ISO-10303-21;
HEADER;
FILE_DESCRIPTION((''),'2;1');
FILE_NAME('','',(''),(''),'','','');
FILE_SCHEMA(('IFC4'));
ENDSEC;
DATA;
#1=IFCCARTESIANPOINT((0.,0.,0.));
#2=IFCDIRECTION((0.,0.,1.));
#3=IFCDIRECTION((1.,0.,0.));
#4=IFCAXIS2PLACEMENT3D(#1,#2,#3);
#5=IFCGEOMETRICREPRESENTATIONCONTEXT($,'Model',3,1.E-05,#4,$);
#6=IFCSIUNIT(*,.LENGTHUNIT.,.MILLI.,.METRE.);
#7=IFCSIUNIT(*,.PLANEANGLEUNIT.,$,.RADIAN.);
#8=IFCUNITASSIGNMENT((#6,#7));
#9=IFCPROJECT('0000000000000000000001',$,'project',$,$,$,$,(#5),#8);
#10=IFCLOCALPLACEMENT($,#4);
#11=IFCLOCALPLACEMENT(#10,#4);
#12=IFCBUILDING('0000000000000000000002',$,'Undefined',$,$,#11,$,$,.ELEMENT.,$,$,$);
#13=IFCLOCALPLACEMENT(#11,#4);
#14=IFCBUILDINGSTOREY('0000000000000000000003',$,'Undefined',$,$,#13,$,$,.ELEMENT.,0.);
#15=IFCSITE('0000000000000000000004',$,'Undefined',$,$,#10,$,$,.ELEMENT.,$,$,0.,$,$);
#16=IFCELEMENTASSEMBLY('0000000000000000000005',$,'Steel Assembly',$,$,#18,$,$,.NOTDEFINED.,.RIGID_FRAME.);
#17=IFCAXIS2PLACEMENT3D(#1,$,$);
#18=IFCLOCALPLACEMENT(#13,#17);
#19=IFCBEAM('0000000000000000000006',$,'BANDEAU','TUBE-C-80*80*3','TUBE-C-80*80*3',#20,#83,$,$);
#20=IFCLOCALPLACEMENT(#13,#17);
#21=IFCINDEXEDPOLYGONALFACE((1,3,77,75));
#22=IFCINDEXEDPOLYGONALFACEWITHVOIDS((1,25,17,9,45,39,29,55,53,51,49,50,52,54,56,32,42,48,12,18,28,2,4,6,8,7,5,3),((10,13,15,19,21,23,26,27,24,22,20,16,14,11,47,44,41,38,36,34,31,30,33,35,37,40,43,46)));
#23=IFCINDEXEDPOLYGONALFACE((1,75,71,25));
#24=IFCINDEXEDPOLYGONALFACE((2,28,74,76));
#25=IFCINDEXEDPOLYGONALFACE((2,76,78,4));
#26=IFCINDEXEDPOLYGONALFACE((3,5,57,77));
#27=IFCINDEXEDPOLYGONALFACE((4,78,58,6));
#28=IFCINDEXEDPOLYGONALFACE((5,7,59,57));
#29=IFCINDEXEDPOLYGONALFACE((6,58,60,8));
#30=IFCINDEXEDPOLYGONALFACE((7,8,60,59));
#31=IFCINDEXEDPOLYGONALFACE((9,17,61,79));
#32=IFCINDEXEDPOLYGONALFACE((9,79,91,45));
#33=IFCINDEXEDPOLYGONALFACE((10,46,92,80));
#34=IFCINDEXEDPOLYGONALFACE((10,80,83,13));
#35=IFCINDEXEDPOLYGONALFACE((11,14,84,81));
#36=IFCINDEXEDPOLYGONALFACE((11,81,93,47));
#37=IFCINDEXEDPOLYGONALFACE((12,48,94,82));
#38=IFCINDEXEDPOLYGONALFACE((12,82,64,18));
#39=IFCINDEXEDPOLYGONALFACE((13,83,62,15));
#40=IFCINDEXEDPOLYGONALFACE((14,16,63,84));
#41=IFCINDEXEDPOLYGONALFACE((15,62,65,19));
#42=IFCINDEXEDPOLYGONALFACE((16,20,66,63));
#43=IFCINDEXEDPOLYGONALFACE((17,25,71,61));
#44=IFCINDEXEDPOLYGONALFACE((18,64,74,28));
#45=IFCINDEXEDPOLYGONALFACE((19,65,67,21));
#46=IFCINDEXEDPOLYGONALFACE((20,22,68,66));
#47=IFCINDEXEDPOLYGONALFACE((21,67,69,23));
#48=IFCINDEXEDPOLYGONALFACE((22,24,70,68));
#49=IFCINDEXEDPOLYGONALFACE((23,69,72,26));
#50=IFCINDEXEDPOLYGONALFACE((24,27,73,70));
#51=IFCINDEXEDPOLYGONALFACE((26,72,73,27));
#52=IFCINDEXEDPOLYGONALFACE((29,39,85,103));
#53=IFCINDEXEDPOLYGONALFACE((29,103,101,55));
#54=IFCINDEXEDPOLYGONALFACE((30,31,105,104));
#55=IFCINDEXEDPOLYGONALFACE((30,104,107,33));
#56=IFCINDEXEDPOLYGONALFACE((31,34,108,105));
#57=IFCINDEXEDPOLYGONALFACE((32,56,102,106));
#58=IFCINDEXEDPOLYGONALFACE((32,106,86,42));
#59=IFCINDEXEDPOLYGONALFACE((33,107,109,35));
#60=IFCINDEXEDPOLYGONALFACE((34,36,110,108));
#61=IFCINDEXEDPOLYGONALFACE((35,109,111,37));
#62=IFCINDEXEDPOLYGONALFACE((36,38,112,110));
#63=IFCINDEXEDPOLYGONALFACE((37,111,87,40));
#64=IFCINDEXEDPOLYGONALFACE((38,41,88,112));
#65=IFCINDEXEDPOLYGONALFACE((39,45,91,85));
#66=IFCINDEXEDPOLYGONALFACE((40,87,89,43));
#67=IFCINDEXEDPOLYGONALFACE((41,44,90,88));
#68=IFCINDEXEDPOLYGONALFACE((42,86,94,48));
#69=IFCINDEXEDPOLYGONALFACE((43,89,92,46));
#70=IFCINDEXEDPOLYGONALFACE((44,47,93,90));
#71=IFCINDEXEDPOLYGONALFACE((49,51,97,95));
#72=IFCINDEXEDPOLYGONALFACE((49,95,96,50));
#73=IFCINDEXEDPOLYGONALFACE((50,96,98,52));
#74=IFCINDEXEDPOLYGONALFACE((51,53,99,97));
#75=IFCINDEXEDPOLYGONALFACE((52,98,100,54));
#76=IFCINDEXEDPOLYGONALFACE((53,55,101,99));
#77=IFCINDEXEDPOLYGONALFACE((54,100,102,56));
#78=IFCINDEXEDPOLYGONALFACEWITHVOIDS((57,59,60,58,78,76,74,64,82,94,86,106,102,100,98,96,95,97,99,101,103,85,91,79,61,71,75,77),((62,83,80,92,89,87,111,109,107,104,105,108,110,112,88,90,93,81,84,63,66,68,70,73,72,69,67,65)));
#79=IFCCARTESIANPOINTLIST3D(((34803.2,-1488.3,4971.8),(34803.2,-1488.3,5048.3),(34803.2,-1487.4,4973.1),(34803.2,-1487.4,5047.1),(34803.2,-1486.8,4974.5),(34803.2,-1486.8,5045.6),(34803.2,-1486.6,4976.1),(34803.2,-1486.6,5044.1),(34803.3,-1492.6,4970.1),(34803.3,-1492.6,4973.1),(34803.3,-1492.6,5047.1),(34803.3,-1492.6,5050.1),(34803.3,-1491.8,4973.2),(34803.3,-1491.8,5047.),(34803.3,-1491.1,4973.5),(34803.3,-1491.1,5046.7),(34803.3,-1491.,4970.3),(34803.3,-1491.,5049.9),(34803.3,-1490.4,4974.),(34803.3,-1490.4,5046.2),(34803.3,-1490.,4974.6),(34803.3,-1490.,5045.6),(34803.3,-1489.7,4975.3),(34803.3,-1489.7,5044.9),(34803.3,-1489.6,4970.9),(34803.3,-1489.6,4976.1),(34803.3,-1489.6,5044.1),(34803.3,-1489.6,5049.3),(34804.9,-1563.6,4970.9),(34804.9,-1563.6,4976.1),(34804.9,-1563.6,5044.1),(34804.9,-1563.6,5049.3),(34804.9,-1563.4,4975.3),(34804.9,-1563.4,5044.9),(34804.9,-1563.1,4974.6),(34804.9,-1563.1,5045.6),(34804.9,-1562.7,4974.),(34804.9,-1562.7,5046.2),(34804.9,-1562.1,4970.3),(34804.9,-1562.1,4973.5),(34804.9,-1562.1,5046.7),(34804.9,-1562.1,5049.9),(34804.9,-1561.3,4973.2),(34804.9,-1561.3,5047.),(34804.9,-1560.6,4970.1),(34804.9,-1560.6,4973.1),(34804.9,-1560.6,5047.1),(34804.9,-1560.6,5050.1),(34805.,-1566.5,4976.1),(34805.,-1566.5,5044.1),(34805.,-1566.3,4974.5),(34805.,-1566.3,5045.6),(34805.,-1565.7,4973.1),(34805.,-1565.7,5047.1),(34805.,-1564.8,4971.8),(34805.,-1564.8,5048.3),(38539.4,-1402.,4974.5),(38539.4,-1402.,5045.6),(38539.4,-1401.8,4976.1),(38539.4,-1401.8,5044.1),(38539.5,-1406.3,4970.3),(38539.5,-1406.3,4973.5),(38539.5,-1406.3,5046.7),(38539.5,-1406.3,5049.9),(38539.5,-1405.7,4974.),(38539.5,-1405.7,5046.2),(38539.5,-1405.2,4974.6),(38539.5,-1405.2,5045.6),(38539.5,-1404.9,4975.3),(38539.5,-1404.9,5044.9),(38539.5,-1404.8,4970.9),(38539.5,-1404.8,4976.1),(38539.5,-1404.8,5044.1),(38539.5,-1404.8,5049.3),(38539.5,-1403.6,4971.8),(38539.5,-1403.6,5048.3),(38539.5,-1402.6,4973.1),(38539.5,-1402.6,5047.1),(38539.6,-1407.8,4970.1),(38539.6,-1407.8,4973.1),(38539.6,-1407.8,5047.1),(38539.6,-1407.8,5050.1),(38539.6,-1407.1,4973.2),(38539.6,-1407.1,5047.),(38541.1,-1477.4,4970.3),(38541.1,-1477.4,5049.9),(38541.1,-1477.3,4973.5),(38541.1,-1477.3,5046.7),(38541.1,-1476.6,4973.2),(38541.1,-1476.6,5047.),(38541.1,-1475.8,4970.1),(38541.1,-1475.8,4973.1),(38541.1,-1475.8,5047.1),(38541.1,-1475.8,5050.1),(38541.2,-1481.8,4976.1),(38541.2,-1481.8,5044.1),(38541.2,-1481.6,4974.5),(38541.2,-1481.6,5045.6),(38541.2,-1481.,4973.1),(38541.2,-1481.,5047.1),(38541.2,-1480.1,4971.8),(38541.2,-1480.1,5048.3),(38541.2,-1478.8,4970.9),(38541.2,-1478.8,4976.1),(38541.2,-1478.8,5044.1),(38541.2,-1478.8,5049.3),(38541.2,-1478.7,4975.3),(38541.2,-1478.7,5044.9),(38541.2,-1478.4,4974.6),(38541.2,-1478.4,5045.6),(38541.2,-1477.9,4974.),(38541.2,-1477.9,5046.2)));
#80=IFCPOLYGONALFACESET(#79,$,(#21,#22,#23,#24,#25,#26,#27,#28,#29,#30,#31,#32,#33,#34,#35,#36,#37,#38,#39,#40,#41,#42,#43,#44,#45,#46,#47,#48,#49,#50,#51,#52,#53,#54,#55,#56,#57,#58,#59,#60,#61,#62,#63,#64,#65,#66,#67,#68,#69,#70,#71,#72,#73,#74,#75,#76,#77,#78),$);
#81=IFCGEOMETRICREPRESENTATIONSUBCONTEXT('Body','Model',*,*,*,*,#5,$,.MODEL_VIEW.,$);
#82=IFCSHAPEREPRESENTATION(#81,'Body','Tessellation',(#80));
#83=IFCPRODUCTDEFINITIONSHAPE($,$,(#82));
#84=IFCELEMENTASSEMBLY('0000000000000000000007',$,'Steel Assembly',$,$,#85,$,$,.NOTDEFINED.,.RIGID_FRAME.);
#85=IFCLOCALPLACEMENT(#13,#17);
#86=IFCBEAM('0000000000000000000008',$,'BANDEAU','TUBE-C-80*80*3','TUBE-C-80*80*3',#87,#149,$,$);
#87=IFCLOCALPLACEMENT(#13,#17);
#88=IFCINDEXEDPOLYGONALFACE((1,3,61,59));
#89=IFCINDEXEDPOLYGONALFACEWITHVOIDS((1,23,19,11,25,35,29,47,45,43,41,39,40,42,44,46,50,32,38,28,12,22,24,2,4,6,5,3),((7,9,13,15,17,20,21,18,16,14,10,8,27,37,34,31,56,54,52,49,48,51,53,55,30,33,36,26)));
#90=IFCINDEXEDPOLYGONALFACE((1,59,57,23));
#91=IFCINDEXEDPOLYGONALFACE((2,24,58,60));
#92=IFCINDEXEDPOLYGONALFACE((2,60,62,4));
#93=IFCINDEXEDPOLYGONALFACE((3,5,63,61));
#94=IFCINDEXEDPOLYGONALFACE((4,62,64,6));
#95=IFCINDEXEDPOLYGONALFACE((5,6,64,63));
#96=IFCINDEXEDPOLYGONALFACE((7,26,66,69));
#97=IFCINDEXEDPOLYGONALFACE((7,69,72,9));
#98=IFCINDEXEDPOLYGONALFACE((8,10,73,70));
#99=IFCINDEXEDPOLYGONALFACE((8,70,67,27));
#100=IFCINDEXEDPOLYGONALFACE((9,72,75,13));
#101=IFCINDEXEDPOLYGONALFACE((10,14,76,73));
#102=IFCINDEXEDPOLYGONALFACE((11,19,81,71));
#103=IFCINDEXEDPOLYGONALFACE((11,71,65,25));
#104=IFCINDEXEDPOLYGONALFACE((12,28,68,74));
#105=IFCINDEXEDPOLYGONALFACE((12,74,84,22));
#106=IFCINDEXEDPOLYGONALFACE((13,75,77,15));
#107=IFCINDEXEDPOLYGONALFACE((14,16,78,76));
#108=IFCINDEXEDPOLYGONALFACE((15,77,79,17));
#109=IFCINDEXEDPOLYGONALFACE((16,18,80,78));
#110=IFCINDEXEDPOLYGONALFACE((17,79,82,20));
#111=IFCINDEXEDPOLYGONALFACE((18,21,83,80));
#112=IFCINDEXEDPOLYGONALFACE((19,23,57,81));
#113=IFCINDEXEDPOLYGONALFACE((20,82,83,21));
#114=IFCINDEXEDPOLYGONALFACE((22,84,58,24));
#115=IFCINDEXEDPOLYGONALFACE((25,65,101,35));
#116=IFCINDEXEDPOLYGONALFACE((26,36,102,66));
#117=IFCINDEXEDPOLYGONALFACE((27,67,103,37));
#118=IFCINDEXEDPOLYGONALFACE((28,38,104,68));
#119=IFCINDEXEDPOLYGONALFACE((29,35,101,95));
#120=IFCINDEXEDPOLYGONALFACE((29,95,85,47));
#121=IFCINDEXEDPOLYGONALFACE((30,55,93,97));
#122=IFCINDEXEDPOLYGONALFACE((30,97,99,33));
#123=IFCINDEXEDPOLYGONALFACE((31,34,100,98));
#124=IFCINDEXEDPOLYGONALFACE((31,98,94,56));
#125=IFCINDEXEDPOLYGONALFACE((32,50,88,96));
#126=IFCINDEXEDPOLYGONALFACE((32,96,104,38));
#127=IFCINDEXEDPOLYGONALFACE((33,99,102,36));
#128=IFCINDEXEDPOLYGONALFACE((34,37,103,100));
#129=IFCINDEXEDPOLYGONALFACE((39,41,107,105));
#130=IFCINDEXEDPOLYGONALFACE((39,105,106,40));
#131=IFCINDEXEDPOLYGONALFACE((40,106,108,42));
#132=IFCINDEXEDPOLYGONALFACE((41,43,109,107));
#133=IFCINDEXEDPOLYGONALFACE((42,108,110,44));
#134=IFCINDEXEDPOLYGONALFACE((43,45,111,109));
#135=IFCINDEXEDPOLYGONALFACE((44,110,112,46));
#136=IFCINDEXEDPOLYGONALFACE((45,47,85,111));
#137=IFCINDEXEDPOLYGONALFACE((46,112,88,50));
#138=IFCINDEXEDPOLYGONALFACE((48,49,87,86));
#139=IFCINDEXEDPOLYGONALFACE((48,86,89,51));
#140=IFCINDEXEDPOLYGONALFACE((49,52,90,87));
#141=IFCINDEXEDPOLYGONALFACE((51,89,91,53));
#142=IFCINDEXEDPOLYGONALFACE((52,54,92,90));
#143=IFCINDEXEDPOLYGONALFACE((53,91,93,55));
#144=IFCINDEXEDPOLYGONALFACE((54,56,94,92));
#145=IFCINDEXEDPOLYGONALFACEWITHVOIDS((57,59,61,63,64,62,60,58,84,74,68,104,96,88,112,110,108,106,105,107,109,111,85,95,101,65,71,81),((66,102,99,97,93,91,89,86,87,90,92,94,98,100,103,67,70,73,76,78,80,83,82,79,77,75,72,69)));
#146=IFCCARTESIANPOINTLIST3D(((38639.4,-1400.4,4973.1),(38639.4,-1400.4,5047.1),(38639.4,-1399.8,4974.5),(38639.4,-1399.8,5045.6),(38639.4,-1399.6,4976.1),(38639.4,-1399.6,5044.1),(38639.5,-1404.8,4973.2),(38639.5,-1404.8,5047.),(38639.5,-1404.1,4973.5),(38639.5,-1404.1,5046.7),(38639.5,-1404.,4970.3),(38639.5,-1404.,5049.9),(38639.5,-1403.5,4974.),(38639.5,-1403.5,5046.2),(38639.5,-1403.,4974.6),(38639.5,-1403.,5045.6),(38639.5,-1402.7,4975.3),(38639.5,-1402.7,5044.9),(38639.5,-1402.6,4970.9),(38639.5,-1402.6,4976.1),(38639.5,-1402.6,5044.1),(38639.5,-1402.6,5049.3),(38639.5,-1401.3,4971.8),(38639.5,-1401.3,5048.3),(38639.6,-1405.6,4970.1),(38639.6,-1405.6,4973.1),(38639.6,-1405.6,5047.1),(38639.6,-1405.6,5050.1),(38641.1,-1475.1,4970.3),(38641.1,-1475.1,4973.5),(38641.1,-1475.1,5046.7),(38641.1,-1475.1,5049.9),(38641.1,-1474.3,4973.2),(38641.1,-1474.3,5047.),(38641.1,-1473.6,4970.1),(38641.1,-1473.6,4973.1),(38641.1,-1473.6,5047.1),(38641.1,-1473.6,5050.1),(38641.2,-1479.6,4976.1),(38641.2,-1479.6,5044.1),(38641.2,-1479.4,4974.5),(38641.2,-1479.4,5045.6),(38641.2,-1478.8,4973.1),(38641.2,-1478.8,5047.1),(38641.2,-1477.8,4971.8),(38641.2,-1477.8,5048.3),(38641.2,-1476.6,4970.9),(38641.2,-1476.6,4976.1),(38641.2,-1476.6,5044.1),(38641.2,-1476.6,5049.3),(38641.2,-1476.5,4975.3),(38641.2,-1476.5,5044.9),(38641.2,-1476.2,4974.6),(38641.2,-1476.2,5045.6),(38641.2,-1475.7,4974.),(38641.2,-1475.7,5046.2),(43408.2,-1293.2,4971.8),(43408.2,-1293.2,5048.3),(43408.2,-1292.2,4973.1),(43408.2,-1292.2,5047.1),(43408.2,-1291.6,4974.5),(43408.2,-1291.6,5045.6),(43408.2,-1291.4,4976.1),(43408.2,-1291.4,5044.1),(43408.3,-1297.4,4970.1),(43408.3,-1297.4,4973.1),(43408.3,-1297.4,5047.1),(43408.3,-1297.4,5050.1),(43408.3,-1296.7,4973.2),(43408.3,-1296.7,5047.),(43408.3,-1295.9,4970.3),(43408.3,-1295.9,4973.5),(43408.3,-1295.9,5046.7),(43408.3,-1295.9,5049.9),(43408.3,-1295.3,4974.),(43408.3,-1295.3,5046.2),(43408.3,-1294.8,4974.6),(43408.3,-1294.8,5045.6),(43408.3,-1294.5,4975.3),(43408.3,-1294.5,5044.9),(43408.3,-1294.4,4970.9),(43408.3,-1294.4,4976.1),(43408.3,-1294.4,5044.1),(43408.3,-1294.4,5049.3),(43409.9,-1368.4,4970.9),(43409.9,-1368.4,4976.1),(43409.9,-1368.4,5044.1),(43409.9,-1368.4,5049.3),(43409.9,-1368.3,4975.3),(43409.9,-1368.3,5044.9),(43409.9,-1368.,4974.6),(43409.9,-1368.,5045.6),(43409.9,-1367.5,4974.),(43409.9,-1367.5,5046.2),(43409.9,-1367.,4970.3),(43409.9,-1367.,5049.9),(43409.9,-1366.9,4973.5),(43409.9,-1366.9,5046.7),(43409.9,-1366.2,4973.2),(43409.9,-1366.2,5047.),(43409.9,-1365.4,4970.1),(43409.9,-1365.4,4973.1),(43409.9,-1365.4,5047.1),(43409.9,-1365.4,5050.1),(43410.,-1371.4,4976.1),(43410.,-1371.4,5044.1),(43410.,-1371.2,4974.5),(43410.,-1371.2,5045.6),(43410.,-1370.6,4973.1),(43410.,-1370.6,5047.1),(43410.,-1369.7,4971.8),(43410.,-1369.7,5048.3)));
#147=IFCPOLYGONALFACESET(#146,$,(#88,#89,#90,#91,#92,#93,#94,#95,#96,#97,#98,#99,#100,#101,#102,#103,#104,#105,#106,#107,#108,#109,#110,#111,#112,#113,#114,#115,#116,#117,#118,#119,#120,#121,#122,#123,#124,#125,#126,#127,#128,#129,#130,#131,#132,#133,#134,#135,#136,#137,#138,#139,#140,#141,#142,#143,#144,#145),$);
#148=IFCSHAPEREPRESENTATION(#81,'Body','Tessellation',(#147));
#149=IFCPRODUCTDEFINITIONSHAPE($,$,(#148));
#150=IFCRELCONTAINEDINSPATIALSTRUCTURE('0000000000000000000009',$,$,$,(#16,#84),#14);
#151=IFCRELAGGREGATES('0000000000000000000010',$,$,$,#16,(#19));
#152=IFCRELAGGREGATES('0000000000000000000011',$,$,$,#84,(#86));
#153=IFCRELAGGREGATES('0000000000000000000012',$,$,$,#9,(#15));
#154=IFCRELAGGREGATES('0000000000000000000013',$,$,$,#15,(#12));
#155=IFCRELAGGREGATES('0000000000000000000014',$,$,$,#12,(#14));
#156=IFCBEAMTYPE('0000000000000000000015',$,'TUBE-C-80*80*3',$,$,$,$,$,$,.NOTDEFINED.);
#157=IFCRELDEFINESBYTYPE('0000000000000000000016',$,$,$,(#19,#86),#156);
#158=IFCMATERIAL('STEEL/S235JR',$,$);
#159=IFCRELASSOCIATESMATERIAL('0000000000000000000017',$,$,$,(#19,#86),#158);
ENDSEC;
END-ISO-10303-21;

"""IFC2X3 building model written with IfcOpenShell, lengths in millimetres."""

from ifc_helpers import new_model, si_unit, frame, origin_with_axes, origin_2d_with_axis, place, context, subcontext, project, spatial, hollow_rectangle, extrude, material, type_object, element, aggregate, save


model = new_model("IFC2X3")

# Units and contexts
model_context = context("Model", 3, precision=1e-05, world=origin_with_axes())
body_context = subcontext(model_context, "Body", "Model", "MODEL_VIEW")
ifc_project = project(units=[si_unit("LENGTHUNIT", "METRE", prefix="MILLI"), si_unit("PLANEANGLEUNIT", "RADIAN")], contexts=[model_context])

# Site, building, storey
site_placement = place(None, origin_with_axes())
site = spatial("IfcSite", under=ifc_project, at=site_placement, Name="Undefined", CompositionType="ELEMENT", RefElevation=0.0)
building_placement = place(site_placement, origin_with_axes())
building = spatial("IfcBuilding", under=site, at=building_placement, Name="Undefined", CompositionType="ELEMENT")
storey_placement = place(building_placement, origin_with_axes())
storey = spatial("IfcBuildingStorey", under=building, at=storey_placement, Name="Undefined", CompositionType="ELEMENT", Elevation=0.0)

# Element assemblies, beams
assembly_1_placement = place(storey_placement, origin_with_axes())
assembly_1 = element("IfcElementAssembly", 1, at=assembly_1_placement, inside=storey, Name="Steel Assembly", AssemblyPlace="NOTDEFINED", PredefinedType="RIGID_FRAME")
ifc_material_1 = material(Name="STEEL/S235JR")
beam_type_1 = type_object("IfcBeamType", Name="TUBE-C-80*80*3", PredefinedType="NOTDEFINED")
beam_1_placement = place(assembly_1_placement, frame((38540.4, -1441.8, 5010.1), z_axis=(-0.022671, 0.999743, 0.0), x_axis=(-0.999743, -0.022671, 0.0)))
beam_1 = element("IfcBeam", 2, at=beam_1_placement, type_object=beam_type_1, material=ifc_material_1, Name="BANDEAU", Description="TUBE-C-80*80*3", ObjectType="TUBE-C-80*80*3", context=body_context, shape_type="SweptSolid", body=[
    extrude(hollow_rectangle(XDim=80.0, YDim=80.0, WallThickness=3.0, InnerFilletRadius=3.0, OuterFilletRadius=6.0, at=origin_2d_with_axis()), frame((3737.2, 0.0, 0.0), z_axis=(-1.0, 0.0, 0.0), x_axis=(0.0, -1.0, 0.0)), (0.0, 0.0, 1.0), 3737.2),
])
aggregate(assembly_1, [beam_1])
assembly_2_placement = place(storey_placement, origin_with_axes())
assembly_2 = element("IfcElementAssembly", 3, at=assembly_2_placement, inside=storey, Name="Steel Assembly", AssemblyPlace="NOTDEFINED", PredefinedType="RIGID_FRAME")
beam_2_placement = place(assembly_2_placement, frame((43409.1, -1331.4, 5010.1), z_axis=(-0.022671, 0.999743, 0.0), x_axis=(-0.999743, -0.022671, 0.0)))
beam_2 = element("IfcBeam", 4, at=beam_2_placement, type_object=beam_type_1, material=ifc_material_1, Name="BANDEAU", Description="TUBE-C-80*80*3", ObjectType="TUBE-C-80*80*3", context=body_context, shape_type="SweptSolid", body=[
    extrude(hollow_rectangle(XDim=80.0, YDim=80.0, WallThickness=3.0, InnerFilletRadius=3.0, OuterFilletRadius=6.0, at=origin_2d_with_axis()), frame((4770.0, 0.0, 0.0), z_axis=(-1.0, 0.0, 0.0), x_axis=(0.0, -1.0, 0.0)), (0.0, 0.0, 1.0), 4770.0),
])

aggregate(assembly_2, [beam_2])

save(model, "model.ifc")
